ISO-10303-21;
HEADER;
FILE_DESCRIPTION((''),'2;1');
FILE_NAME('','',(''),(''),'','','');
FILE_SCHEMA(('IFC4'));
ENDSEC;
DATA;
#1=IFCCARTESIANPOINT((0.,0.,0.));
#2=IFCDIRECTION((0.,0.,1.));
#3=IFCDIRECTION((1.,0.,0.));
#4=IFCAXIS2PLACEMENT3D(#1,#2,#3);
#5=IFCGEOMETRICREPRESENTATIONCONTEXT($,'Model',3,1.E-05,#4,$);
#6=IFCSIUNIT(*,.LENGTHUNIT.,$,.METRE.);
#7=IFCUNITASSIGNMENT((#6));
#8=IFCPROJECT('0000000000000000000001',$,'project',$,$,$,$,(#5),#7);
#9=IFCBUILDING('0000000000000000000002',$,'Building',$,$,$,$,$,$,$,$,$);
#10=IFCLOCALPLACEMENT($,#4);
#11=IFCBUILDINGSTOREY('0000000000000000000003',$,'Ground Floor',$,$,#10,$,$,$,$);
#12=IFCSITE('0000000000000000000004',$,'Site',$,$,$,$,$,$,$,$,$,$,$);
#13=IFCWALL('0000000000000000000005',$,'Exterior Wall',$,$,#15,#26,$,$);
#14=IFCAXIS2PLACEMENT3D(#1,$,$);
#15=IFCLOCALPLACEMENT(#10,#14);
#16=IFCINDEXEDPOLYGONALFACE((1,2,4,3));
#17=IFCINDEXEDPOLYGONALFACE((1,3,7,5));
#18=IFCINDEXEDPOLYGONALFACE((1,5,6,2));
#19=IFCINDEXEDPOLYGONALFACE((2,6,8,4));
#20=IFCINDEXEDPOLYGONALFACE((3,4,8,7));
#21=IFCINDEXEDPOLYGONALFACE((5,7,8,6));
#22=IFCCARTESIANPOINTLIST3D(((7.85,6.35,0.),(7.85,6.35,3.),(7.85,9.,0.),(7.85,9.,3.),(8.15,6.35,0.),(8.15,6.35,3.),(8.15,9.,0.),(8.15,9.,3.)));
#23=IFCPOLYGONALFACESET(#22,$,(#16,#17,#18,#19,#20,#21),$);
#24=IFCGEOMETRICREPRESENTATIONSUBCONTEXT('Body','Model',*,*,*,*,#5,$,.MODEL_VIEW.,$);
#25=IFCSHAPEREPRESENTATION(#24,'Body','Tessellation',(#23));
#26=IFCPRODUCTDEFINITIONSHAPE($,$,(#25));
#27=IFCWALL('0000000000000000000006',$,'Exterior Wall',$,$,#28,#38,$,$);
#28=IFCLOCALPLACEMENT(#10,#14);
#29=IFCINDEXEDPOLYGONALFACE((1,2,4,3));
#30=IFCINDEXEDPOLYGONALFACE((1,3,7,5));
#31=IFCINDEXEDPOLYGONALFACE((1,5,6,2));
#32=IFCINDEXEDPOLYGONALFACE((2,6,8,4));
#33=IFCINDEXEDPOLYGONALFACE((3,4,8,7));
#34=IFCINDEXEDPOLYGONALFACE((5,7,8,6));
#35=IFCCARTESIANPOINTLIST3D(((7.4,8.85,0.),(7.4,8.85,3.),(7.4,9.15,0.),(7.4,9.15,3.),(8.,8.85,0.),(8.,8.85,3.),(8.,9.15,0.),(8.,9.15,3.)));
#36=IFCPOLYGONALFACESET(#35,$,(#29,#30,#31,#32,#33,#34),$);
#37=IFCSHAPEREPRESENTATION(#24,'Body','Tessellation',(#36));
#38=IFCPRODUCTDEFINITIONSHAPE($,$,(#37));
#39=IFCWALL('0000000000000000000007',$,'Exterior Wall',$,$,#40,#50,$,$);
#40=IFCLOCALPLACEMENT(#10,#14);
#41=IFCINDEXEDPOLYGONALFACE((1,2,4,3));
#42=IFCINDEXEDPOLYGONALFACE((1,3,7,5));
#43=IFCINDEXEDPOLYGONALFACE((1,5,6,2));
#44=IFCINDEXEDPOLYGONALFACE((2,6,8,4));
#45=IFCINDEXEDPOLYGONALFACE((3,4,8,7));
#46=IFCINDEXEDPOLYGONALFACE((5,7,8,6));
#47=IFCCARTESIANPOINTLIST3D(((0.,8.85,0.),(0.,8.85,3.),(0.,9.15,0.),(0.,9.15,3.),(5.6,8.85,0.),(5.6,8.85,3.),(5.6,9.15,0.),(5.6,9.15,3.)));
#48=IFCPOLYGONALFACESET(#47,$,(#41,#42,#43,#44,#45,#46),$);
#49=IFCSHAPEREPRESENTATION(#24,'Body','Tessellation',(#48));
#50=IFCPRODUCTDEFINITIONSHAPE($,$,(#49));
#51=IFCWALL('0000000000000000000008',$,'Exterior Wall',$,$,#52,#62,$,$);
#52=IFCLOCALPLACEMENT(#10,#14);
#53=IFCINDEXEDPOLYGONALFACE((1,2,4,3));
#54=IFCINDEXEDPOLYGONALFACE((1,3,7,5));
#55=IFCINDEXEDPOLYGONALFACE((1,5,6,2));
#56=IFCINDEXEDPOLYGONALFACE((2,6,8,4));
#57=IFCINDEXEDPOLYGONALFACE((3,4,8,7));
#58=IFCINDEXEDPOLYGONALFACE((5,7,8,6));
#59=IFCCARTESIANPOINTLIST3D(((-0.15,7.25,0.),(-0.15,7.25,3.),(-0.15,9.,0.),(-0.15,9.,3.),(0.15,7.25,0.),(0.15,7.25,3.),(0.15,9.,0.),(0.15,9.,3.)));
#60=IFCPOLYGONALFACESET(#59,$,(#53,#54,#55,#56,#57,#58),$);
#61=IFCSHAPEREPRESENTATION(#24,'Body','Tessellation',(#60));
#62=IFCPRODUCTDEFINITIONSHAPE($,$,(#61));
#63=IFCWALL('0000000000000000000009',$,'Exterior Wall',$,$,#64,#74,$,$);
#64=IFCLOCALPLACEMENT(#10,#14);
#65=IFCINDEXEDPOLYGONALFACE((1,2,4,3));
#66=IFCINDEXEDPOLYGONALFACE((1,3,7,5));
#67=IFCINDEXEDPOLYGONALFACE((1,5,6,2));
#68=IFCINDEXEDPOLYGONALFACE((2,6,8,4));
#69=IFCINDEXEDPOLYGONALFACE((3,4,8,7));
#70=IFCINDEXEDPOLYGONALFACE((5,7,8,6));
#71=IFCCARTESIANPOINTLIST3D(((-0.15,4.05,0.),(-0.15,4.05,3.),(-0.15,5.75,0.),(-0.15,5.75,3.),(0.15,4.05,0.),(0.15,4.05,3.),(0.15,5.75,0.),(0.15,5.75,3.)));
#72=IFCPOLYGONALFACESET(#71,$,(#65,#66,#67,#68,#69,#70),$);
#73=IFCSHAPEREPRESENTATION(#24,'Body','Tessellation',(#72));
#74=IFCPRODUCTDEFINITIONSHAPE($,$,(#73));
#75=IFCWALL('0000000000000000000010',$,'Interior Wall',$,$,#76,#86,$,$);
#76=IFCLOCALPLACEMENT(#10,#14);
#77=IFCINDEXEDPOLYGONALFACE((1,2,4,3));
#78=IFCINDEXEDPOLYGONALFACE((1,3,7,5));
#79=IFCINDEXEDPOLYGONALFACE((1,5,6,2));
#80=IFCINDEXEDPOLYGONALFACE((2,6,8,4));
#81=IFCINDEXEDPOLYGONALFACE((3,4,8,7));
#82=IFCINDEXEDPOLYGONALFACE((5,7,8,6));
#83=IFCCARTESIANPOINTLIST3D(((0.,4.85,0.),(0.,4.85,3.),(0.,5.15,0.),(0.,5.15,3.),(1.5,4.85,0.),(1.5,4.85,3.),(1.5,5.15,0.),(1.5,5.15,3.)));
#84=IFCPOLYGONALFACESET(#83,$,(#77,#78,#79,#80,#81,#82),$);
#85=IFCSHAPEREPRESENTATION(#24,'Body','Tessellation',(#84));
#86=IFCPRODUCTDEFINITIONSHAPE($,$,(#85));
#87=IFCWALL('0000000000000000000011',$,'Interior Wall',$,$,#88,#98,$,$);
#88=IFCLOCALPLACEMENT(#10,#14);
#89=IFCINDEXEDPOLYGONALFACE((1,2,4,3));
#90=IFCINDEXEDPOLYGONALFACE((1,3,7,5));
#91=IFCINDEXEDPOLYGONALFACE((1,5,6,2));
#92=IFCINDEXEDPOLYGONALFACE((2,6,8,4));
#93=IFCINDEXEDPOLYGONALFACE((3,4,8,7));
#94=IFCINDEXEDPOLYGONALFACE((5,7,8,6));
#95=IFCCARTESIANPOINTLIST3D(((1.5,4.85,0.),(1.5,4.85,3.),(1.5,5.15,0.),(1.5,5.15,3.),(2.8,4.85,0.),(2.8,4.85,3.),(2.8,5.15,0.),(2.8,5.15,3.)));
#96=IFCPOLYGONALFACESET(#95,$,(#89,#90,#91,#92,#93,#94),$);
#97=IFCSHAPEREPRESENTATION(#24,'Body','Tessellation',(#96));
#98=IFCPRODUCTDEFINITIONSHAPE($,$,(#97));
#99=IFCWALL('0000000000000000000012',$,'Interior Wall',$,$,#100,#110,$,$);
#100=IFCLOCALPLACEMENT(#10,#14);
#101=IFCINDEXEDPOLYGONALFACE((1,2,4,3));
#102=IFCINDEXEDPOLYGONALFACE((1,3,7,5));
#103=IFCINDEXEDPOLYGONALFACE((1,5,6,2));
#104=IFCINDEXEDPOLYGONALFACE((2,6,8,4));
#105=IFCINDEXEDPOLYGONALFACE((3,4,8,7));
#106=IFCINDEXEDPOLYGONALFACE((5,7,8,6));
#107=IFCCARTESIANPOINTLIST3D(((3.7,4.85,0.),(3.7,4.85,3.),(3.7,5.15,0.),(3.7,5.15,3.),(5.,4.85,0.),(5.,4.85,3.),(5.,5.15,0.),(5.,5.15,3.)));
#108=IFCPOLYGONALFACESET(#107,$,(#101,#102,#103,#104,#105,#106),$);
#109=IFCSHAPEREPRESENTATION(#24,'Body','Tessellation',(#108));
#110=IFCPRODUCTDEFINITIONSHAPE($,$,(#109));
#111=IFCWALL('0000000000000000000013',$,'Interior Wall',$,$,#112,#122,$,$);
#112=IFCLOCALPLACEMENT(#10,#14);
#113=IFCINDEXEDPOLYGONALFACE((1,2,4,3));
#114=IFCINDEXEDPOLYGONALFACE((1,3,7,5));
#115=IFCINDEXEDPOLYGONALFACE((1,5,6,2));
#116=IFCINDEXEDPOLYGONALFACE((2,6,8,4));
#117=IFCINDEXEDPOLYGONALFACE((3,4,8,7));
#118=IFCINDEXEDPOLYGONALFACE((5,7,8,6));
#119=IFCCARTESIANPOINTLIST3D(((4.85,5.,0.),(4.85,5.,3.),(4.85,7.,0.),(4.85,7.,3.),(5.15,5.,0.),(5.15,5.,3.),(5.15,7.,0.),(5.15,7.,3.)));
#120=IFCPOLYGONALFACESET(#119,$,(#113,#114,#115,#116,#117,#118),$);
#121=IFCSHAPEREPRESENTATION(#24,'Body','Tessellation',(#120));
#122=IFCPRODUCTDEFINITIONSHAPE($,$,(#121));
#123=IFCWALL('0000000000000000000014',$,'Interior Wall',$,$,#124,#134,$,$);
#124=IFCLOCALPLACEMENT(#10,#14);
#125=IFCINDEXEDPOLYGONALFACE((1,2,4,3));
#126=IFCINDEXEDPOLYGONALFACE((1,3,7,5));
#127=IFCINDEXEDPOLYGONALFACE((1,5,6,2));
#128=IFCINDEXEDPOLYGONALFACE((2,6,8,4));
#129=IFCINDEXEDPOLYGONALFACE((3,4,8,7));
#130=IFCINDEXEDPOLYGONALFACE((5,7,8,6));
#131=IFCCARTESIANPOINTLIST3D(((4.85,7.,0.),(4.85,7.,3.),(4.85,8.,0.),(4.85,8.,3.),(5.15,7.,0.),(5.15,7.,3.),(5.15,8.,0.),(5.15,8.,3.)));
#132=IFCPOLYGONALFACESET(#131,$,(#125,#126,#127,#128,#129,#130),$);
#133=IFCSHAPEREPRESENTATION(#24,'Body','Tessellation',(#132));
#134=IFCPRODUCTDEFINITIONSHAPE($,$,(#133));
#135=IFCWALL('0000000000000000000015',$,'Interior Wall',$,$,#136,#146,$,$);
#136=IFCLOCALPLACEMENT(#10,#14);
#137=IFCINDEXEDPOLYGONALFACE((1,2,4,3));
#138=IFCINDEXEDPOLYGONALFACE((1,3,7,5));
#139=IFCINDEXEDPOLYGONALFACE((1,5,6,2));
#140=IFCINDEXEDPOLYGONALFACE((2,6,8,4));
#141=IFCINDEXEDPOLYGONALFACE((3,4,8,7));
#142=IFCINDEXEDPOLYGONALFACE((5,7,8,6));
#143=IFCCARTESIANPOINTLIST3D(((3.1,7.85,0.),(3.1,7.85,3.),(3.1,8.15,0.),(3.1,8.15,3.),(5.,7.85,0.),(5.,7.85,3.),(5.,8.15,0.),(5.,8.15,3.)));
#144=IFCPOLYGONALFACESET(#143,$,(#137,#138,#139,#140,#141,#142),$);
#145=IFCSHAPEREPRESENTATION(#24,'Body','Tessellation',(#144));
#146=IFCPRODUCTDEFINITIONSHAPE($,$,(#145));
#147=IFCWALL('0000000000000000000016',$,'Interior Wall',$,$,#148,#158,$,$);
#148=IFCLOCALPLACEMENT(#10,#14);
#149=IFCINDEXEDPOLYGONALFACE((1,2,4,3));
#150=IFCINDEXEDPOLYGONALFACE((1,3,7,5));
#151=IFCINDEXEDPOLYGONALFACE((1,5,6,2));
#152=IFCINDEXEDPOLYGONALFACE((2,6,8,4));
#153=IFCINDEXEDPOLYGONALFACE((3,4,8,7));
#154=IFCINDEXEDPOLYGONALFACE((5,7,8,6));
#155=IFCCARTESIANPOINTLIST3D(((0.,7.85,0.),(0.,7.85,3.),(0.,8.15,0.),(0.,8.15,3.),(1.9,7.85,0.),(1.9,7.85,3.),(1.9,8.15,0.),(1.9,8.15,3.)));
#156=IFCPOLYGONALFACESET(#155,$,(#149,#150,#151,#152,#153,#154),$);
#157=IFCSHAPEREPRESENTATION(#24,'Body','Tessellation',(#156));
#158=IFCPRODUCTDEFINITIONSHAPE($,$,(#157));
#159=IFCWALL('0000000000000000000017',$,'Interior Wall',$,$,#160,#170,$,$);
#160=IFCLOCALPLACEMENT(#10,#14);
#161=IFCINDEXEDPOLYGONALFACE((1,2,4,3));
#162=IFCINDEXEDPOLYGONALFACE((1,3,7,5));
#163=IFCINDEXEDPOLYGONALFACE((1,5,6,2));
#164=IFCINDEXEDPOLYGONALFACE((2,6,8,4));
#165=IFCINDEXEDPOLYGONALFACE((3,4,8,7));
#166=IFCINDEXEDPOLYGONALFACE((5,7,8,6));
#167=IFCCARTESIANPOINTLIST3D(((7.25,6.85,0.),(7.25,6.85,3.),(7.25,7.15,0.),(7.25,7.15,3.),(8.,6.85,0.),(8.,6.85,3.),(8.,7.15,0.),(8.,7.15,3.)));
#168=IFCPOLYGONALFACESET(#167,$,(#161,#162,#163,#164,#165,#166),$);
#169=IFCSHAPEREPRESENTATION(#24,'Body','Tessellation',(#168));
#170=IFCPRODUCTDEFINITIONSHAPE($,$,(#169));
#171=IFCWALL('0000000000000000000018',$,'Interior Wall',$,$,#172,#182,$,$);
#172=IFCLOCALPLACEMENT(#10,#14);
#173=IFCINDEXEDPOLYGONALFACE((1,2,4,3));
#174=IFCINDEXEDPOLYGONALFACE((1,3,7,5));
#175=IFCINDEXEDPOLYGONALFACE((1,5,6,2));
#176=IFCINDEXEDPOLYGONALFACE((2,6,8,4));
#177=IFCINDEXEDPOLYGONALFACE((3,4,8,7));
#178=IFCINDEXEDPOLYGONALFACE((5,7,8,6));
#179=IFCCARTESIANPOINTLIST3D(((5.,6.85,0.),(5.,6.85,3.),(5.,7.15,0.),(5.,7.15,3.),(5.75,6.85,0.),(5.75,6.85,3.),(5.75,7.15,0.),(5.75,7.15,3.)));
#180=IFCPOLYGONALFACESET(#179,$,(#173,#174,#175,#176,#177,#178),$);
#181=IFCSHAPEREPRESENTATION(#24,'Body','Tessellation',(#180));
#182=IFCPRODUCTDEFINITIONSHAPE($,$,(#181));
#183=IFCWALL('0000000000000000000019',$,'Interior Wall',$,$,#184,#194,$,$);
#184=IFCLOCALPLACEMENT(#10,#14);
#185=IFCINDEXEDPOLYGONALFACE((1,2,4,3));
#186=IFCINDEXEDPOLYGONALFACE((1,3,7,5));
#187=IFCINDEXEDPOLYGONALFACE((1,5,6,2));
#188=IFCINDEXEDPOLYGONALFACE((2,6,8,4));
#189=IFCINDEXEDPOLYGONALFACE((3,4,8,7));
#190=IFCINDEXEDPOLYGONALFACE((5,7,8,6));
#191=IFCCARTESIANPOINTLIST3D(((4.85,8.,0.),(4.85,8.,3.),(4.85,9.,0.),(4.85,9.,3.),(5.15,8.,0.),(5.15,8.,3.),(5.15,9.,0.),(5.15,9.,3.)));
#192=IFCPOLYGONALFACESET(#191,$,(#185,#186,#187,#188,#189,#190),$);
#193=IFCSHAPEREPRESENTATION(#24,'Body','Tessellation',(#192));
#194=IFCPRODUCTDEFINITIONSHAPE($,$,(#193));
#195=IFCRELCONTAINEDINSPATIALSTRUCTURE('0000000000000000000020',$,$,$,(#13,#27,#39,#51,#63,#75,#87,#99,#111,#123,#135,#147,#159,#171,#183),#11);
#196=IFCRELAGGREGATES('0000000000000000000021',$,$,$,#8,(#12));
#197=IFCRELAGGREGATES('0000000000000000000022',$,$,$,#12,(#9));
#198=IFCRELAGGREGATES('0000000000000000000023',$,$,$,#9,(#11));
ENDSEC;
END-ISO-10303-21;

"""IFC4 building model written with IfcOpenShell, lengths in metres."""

from ifc_helpers import new_model, si_unit, frame, origin_with_axes, place, context, subcontext, project, spatial, indexed_curve, outline, extrude, element, save


model = new_model("IFC4")

# Units and contexts
model_context = context("Model", 3, precision=1e-05, world=origin_with_axes())
body_context = subcontext(model_context, "Body", "Model", "MODEL_VIEW")
ifc_project = project(units=[si_unit("LENGTHUNIT", "METRE")], contexts=[model_context])

# Site, building, storey
site = spatial("IfcSite", under=ifc_project, Name="Site")
building = spatial("IfcBuilding", under=site, Name="Building")
storey_placement = place(None, origin_with_axes())
storey = spatial("IfcBuildingStorey", under=building, at=storey_placement, Name="Ground Floor")

# Walls
wall_1_placement = place(storey_placement, frame((8.0, 6.35, 0.0), z_axis=(0.0, 0.0, 1.0), x_axis=(0.0, 1.0, 0.0)))
element("IfcWall", 1, at=wall_1_placement, inside=storey, Name="Exterior Wall", context=body_context, shape_type="SweptSolid", body=[
    extrude(outline(indexed_curve([(0.0, 0.0), (0.0, 0.3), (2.65, 0.3), (2.65, 0.0), (0.0, 0.0)], self_intersect=False)), frame((0.0, -0.15, 0.0), z_axis=(0.0, 0.0, 1.0), x_axis=(1.0, 0.0, 0.0)), (0.0, 0.0, 1.0), 3.0),
])
wall_2_placement = place(storey_placement, frame((8.0, 9.0, 0.0), z_axis=(0.0, 0.0, 1.0), x_axis=(-1.0, 0.0, 0.0)))
element("IfcWall", 2, at=wall_2_placement, inside=storey, Name="Exterior Wall", context=body_context, shape_type="SweptSolid", body=[
    extrude(outline(indexed_curve([(0.0, 0.0), (0.0, 0.3), (0.6, 0.3), (0.6, 0.0), (0.0, 0.0)], self_intersect=False)), frame((0.0, -0.15, 0.0), z_axis=(0.0, 0.0, 1.0), x_axis=(1.0, 0.0, 0.0)), (0.0, 0.0, 1.0), 3.0),
])
wall_3_placement = place(storey_placement, frame((5.6, 9.0, 0.0), z_axis=(0.0, 0.0, 1.0), x_axis=(-1.0, 0.0, 0.0)))
element("IfcWall", 3, at=wall_3_placement, inside=storey, Name="Exterior Wall", context=body_context, shape_type="SweptSolid", body=[
    extrude(outline(indexed_curve([(0.0, 0.0), (0.0, 0.3), (5.6, 0.3), (5.6, 0.0), (0.0, 0.0)], self_intersect=False)), frame((0.0, -0.15, 0.0), z_axis=(0.0, 0.0, 1.0), x_axis=(1.0, 0.0, 0.0)), (0.0, 0.0, 1.0), 3.0),
])
wall_4_placement = place(storey_placement, frame((0.0, 9.0, 0.0), z_axis=(0.0, 0.0, 1.0), x_axis=(0.0, -1.0, 0.0)))
element("IfcWall", 4, at=wall_4_placement, inside=storey, Name="Exterior Wall", context=body_context, shape_type="SweptSolid", body=[
    extrude(outline(indexed_curve([(0.0, 0.0), (0.0, 0.3), (1.75, 0.3), (1.75, 0.0), (0.0, 0.0)], self_intersect=False)), frame((0.0, -0.15, 0.0), z_axis=(0.0, 0.0, 1.0), x_axis=(1.0, 0.0, 0.0)), (0.0, 0.0, 1.0), 3.0),
])
wall_5_placement = place(storey_placement, frame((0.0, 5.75, 0.0), z_axis=(0.0, 0.0, 1.0), x_axis=(0.0, -1.0, 0.0)))
element("IfcWall", 5, at=wall_5_placement, inside=storey, Name="Exterior Wall", context=body_context, shape_type="SweptSolid", body=[
    extrude(outline(indexed_curve([(0.0, 0.0), (0.0, 0.3), (1.7, 0.3), (1.7, 0.0), (0.0, 0.0)], self_intersect=False)), frame((0.0, -0.15, 0.0), z_axis=(0.0, 0.0, 1.0), x_axis=(1.0, 0.0, 0.0)), (0.0, 0.0, 1.0), 3.0),
])
wall_6_placement = place(storey_placement, frame((1.5, 5.0, 0.0), z_axis=(0.0, 0.0, 1.0), x_axis=(-1.0, 0.0, 0.0)))
element("IfcWall", 6, at=wall_6_placement, inside=storey, Name="Interior Wall", context=body_context, shape_type="SweptSolid", body=[
    extrude(outline(indexed_curve([(0.0, 0.0), (0.0, 0.3), (1.5, 0.3), (1.5, 0.0), (0.0, 0.0)], self_intersect=False)), frame((0.0, -0.15, 0.0), z_axis=(0.0, 0.0, 1.0), x_axis=(1.0, 0.0, 0.0)), (0.0, 0.0, 1.0), 3.0),
])
for number, where, z_axis, x_axis, name in (
    (7, (1.5, 5.0, 0.0), (0.0, 0.0, 1.0), (1.0, 0.0, 0.0), "Interior Wall"),
    (8, (3.7, 5.0, 0.0), (0.0, 0.0, 1.0), (1.0, 0.0, 0.0), "Interior Wall"),
):
    element("IfcWall", number, at=place(storey_placement, frame(where, z_axis=z_axis, x_axis=x_axis)), inside=storey, Name=name, context=body_context, shape_type="SweptSolid", body=[
        extrude(outline(indexed_curve([(0.0, 0.0), (0.0, 0.3), (1.3, 0.3), (1.3, 0.0), (0.0, 0.0)], self_intersect=False)), frame((0.0, -0.15, 0.0), z_axis=(0.0, 0.0, 1.0), x_axis=(1.0, 0.0, 0.0)), (0.0, 0.0, 1.0), 3.0),
    ])
wall_7_placement = place(storey_placement, frame((5.0, 5.0, 0.0), z_axis=(0.0, 0.0, 1.0), x_axis=(0.0, 1.0, 0.0)))
element("IfcWall", 9, at=wall_7_placement, inside=storey, Name="Interior Wall", context=body_context, shape_type="SweptSolid", body=[
    extrude(outline(indexed_curve([(0.0, 0.0), (0.0, 0.3), (2.0, 0.3), (2.0, 0.0), (0.0, 0.0)], self_intersect=False)), frame((0.0, -0.15, 0.0), z_axis=(0.0, 0.0, 1.0), x_axis=(1.0, 0.0, 0.0)), (0.0, 0.0, 1.0), 3.0),
])
wall_8_placement = place(storey_placement, frame((5.0, 7.0, 0.0), z_axis=(0.0, 0.0, 1.0), x_axis=(0.0, 1.0, 0.0)))
element("IfcWall", 10, at=wall_8_placement, inside=storey, Name="Interior Wall", context=body_context, shape_type="SweptSolid", body=[
    extrude(outline(indexed_curve([(0.0, 0.0), (0.0, 0.3), (1.0, 0.3), (1.0, 0.0), (0.0, 0.0)], self_intersect=False)), frame((0.0, -0.15, 0.0), z_axis=(0.0, 0.0, 1.0), x_axis=(1.0, 0.0, 0.0)), (0.0, 0.0, 1.0), 3.0),
])
for number, where, z_axis, x_axis, name in (
    (11, (5.0, 8.0, 0.0), (0.0, 0.0, 1.0), (-1.0, 0.0, 0.0), "Interior Wall"),
    (12, (1.9, 8.0, 0.0), (0.0, 0.0, 1.0), (-1.0, 0.0, 0.0), "Interior Wall"),
):
    element("IfcWall", number, at=place(storey_placement, frame(where, z_axis=z_axis, x_axis=x_axis)), inside=storey, Name=name, context=body_context, shape_type="SweptSolid", body=[
        extrude(outline(indexed_curve([(0.0, 0.0), (0.0, 0.3), (1.9, 0.3), (1.9, 0.0), (0.0, 0.0)], self_intersect=False)), frame((0.0, -0.15, 0.0), z_axis=(0.0, 0.0, 1.0), x_axis=(1.0, 0.0, 0.0)), (0.0, 0.0, 1.0), 3.0),
    ])
for number, where, z_axis, x_axis, name in (
    (13, (8.0, 7.0, 0.0), (0.0, 0.0, 1.0), (-1.0, 0.0, 0.0), "Interior Wall"),
    (14, (5.75, 7.0, 0.0), (0.0, 0.0, 1.0), (-1.0, 0.0, 0.0), "Interior Wall"),
):
    element("IfcWall", number, at=place(storey_placement, frame(where, z_axis=z_axis, x_axis=x_axis)), inside=storey, Name=name, context=body_context, shape_type="SweptSolid", body=[
        extrude(outline(indexed_curve([(0.0, 0.0), (0.0, 0.3), (0.75, 0.3), (0.75, 0.0), (0.0, 0.0)], self_intersect=False)), frame((0.0, -0.15, 0.0), z_axis=(0.0, 0.0, 1.0), x_axis=(1.0, 0.0, 0.0)), (0.0, 0.0, 1.0), 3.0),
    ])
wall_9_placement = place(storey_placement, frame((5.0, 9.0, 0.0), z_axis=(0.0, 0.0, 1.0), x_axis=(0.0, -1.0, 0.0)))
element("IfcWall", 15, at=wall_9_placement, inside=storey, Name="Interior Wall", context=body_context, shape_type="SweptSolid", body=[
    extrude(outline(indexed_curve([(0.0, 0.0), (0.0, 0.3), (1.0, 0.3), (1.0, 0.0), (0.0, 0.0)], self_intersect=False)), frame((0.0, -0.15, 0.0), z_axis=(0.0, 0.0, 1.0), x_axis=(1.0, 0.0, 0.0)), (0.0, 0.0, 1.0), 3.0),
])

save(model, "model.ifc")
